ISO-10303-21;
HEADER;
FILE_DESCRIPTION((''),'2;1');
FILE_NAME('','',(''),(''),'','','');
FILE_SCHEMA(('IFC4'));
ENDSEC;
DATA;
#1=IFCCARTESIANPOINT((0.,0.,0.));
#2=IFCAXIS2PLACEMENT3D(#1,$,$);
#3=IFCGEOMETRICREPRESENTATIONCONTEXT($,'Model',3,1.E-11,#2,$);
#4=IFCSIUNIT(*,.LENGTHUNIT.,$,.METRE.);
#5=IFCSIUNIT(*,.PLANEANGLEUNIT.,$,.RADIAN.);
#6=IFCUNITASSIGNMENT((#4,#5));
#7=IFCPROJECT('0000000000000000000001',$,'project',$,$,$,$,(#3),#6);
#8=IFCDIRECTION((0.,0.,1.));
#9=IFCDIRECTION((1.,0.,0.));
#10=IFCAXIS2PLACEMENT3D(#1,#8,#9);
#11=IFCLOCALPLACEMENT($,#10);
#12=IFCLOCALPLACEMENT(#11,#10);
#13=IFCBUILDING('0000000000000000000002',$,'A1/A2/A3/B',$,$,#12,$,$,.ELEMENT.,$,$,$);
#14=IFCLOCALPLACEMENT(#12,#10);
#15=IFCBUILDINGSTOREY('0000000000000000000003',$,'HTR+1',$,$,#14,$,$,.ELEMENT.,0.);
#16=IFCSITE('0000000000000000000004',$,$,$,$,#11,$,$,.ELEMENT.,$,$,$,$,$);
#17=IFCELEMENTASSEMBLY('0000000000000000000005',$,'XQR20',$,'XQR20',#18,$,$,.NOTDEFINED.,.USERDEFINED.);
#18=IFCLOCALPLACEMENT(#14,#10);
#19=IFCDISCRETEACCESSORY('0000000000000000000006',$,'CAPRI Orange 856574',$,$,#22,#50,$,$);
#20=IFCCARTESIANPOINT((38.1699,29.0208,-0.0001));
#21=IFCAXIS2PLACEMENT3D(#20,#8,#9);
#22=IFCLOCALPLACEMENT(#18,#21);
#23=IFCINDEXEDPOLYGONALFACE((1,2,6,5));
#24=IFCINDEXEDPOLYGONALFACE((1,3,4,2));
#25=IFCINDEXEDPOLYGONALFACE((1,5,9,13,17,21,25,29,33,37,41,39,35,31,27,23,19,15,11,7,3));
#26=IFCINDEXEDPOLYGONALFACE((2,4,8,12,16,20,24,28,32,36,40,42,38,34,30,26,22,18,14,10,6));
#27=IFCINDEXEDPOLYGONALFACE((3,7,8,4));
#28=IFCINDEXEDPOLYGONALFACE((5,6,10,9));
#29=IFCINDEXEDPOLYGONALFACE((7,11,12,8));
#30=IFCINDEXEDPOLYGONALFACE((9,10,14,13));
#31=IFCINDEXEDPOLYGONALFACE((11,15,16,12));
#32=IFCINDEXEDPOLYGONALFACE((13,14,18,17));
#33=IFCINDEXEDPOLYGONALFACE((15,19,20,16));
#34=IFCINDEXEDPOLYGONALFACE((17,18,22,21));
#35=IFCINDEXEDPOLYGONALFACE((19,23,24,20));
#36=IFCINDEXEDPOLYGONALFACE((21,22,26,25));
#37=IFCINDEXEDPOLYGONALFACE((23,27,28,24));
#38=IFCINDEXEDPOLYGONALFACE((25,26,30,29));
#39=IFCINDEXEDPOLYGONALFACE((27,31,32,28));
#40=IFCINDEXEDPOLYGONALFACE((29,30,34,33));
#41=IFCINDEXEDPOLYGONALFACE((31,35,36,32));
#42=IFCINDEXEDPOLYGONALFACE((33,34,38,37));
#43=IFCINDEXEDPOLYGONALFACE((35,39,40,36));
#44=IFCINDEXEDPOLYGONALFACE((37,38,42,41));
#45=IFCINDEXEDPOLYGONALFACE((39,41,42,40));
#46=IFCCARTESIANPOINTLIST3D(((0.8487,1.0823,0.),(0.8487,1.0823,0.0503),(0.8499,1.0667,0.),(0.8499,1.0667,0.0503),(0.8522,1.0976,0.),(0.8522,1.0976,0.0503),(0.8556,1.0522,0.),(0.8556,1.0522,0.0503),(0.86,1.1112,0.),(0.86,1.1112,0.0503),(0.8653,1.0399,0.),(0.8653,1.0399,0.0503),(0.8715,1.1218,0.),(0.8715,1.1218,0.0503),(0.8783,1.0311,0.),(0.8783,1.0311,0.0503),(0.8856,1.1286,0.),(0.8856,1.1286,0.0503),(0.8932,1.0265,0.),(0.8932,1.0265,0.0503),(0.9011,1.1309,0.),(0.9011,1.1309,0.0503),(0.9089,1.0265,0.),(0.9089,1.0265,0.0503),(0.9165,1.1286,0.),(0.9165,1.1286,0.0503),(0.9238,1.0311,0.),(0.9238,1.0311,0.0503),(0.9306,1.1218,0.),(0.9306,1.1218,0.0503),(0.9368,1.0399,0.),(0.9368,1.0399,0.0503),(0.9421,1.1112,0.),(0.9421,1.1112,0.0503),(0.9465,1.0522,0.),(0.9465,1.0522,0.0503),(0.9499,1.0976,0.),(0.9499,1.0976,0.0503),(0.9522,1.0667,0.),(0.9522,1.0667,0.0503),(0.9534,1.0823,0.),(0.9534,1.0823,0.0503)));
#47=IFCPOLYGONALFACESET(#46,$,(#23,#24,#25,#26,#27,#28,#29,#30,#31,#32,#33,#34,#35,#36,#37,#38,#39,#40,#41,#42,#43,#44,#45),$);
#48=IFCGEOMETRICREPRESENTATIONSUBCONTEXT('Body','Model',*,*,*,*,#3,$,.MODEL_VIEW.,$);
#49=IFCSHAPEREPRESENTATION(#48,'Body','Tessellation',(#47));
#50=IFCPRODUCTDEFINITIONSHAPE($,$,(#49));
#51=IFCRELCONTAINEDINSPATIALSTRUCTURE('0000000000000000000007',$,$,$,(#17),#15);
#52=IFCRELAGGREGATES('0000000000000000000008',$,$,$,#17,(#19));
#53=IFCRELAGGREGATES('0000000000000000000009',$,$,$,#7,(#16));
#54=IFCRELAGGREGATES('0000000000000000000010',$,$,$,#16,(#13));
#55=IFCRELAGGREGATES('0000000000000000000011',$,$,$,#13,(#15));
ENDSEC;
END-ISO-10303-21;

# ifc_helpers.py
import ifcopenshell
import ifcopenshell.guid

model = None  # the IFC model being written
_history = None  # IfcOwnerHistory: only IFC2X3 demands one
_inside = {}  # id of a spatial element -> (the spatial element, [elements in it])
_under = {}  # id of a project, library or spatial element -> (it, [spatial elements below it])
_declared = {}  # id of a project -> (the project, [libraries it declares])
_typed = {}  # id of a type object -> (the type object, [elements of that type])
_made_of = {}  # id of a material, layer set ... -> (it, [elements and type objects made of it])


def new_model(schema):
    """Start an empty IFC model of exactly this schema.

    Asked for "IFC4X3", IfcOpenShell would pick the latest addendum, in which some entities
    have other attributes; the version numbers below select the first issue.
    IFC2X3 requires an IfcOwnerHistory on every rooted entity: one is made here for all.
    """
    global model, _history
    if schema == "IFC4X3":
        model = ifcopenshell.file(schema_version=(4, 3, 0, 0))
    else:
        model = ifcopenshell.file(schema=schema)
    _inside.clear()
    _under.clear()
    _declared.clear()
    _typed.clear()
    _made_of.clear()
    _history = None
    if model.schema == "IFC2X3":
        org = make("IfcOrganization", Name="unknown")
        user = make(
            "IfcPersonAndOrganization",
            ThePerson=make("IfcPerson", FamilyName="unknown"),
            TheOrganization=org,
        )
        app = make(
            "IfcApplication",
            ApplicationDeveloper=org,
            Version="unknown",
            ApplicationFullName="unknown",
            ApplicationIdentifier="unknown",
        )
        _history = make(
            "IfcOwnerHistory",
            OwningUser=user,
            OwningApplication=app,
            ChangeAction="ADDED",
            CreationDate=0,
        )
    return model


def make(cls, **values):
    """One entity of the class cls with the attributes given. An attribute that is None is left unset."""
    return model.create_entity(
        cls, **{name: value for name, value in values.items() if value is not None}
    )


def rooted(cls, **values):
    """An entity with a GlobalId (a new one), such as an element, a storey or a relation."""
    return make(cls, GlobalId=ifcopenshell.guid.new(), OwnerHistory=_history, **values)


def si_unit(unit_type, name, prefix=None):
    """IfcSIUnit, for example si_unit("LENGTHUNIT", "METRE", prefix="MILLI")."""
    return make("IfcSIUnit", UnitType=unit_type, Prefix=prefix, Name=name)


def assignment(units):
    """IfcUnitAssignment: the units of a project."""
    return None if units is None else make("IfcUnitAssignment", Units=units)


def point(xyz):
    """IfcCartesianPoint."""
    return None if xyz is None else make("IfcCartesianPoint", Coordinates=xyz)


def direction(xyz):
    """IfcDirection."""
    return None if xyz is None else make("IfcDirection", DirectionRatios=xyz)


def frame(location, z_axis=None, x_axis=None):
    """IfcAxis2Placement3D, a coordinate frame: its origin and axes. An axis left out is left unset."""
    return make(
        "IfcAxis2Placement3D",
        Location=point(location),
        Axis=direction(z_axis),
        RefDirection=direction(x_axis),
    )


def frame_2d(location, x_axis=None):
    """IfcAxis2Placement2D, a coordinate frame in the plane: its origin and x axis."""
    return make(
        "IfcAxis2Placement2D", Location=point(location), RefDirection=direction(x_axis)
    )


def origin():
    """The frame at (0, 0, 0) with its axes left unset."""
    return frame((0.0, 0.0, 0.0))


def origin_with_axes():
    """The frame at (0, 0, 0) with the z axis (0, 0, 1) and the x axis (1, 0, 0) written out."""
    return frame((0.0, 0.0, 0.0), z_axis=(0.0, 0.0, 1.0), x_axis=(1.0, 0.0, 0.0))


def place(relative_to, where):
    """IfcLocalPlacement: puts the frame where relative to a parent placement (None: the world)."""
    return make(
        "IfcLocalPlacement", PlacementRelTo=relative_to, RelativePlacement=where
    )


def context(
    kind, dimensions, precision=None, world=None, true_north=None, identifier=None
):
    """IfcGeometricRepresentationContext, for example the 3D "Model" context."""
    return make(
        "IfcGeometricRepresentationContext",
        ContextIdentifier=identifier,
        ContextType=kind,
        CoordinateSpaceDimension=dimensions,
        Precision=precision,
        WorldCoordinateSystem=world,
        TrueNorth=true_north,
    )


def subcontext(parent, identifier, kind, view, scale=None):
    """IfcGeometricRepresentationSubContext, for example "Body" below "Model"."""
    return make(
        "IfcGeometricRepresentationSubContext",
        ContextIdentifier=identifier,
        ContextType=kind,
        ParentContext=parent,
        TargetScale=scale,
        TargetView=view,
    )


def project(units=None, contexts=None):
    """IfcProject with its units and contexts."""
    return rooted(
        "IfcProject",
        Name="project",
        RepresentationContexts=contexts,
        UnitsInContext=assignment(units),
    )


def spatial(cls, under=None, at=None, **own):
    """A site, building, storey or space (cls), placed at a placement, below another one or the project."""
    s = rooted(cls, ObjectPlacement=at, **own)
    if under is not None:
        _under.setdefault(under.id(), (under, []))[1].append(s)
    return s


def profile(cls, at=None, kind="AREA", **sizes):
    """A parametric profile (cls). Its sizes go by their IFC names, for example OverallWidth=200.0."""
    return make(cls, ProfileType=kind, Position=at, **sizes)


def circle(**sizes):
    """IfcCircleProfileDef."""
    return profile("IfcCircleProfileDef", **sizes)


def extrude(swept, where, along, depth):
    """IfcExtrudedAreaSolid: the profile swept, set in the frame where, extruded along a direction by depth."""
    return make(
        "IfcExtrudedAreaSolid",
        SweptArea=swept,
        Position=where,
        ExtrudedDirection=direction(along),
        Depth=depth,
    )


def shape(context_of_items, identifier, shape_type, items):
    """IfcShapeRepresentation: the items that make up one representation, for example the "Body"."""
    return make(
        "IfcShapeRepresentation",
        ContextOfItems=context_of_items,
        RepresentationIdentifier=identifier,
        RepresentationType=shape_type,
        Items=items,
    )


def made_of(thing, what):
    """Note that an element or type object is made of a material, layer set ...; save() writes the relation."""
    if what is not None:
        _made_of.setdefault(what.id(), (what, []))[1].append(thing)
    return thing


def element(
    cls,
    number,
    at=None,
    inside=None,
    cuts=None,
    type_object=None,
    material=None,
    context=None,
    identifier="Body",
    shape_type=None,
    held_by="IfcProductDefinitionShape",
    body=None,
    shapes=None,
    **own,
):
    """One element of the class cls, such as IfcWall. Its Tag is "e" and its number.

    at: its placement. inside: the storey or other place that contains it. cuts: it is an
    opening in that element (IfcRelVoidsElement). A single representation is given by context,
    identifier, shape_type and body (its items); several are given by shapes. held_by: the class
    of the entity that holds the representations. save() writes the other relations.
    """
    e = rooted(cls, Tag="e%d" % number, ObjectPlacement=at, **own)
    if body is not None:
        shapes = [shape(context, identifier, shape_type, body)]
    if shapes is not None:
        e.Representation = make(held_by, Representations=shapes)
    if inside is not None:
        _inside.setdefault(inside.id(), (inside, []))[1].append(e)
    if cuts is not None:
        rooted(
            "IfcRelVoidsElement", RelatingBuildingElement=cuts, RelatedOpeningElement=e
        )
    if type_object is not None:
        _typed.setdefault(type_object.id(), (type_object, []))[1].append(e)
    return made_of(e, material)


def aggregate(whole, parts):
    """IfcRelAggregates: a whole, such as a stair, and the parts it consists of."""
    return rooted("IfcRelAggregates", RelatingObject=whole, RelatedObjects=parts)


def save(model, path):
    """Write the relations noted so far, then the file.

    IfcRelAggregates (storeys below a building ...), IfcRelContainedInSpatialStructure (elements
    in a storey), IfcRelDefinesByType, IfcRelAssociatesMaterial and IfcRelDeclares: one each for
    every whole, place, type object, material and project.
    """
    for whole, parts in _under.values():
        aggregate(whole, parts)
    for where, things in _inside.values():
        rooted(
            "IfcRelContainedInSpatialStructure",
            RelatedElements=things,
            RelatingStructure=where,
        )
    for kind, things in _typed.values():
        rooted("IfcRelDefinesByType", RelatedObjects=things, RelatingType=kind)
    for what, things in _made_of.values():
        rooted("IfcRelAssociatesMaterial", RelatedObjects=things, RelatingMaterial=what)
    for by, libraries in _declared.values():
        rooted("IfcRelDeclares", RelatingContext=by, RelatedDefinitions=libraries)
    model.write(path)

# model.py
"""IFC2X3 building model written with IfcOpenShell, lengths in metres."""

from ifc_helpers import new_model, si_unit, frame, frame_2d, origin, origin_with_axes, place, context, subcontext, project, spatial, circle, extrude, element, aggregate, save


model = new_model("IFC2X3")

# Units and contexts
model_context = context("Model", 3, precision=1e-11, world=origin())
body_context = subcontext(model_context, "Body", "Model", "MODEL_VIEW")
ifc_project = project(units=[si_unit("LENGTHUNIT", "METRE"), si_unit("PLANEANGLEUNIT", "RADIAN")], contexts=[model_context])

# Site, building, storey
site_placement = place(None, origin_with_axes())
site = spatial("IfcSite", under=ifc_project, at=site_placement, CompositionType="ELEMENT")
building_placement = place(site_placement, origin_with_axes())
building = spatial("IfcBuilding", under=site, at=building_placement, Name="A1/A2/A3/B", CompositionType="ELEMENT")
storey_placement = place(building_placement, origin_with_axes())
storey = spatial("IfcBuildingStorey", under=building, at=storey_placement, Name="HTR+1", CompositionType="ELEMENT", Elevation=0.0)

# Element assembly
assembly_1_placement = place(storey_placement, origin_with_axes())
assembly_1 = element("IfcElementAssembly", 1, at=assembly_1_placement, inside=storey, Name="XQR20", ObjectType="XQR20", AssemblyPlace="NOTDEFINED", PredefinedType="USERDEFINED")

# Discrete accessory
discrete_accessory_1_placement = place(assembly_1_placement, frame((38.1699, 29.0208, -0.0001), z_axis=(0.0, 0.0, 1.0), x_axis=(1.0, 0.0, 0.0)))
discrete_accessory_1 = element("IfcDiscreteAccessory", 2, at=discrete_accessory_1_placement, Name="CAPRI Orange 856574", context=body_context, shape_type="SweptSolid", body=[
    extrude(circle(Radius=0.0525, at=frame_2d((1.0784, -0.9011), x_axis=(1.0, 0.0))), frame((0.0, 0.0, 0.0), z_axis=(0.0, 0.0, 1.0), x_axis=(0.0, 1.0, 0.0)), (0.0, 0.0, 1.0), 0.0503),
])

aggregate(assembly_1, [discrete_accessory_1])

save(model, "model.ifc")
